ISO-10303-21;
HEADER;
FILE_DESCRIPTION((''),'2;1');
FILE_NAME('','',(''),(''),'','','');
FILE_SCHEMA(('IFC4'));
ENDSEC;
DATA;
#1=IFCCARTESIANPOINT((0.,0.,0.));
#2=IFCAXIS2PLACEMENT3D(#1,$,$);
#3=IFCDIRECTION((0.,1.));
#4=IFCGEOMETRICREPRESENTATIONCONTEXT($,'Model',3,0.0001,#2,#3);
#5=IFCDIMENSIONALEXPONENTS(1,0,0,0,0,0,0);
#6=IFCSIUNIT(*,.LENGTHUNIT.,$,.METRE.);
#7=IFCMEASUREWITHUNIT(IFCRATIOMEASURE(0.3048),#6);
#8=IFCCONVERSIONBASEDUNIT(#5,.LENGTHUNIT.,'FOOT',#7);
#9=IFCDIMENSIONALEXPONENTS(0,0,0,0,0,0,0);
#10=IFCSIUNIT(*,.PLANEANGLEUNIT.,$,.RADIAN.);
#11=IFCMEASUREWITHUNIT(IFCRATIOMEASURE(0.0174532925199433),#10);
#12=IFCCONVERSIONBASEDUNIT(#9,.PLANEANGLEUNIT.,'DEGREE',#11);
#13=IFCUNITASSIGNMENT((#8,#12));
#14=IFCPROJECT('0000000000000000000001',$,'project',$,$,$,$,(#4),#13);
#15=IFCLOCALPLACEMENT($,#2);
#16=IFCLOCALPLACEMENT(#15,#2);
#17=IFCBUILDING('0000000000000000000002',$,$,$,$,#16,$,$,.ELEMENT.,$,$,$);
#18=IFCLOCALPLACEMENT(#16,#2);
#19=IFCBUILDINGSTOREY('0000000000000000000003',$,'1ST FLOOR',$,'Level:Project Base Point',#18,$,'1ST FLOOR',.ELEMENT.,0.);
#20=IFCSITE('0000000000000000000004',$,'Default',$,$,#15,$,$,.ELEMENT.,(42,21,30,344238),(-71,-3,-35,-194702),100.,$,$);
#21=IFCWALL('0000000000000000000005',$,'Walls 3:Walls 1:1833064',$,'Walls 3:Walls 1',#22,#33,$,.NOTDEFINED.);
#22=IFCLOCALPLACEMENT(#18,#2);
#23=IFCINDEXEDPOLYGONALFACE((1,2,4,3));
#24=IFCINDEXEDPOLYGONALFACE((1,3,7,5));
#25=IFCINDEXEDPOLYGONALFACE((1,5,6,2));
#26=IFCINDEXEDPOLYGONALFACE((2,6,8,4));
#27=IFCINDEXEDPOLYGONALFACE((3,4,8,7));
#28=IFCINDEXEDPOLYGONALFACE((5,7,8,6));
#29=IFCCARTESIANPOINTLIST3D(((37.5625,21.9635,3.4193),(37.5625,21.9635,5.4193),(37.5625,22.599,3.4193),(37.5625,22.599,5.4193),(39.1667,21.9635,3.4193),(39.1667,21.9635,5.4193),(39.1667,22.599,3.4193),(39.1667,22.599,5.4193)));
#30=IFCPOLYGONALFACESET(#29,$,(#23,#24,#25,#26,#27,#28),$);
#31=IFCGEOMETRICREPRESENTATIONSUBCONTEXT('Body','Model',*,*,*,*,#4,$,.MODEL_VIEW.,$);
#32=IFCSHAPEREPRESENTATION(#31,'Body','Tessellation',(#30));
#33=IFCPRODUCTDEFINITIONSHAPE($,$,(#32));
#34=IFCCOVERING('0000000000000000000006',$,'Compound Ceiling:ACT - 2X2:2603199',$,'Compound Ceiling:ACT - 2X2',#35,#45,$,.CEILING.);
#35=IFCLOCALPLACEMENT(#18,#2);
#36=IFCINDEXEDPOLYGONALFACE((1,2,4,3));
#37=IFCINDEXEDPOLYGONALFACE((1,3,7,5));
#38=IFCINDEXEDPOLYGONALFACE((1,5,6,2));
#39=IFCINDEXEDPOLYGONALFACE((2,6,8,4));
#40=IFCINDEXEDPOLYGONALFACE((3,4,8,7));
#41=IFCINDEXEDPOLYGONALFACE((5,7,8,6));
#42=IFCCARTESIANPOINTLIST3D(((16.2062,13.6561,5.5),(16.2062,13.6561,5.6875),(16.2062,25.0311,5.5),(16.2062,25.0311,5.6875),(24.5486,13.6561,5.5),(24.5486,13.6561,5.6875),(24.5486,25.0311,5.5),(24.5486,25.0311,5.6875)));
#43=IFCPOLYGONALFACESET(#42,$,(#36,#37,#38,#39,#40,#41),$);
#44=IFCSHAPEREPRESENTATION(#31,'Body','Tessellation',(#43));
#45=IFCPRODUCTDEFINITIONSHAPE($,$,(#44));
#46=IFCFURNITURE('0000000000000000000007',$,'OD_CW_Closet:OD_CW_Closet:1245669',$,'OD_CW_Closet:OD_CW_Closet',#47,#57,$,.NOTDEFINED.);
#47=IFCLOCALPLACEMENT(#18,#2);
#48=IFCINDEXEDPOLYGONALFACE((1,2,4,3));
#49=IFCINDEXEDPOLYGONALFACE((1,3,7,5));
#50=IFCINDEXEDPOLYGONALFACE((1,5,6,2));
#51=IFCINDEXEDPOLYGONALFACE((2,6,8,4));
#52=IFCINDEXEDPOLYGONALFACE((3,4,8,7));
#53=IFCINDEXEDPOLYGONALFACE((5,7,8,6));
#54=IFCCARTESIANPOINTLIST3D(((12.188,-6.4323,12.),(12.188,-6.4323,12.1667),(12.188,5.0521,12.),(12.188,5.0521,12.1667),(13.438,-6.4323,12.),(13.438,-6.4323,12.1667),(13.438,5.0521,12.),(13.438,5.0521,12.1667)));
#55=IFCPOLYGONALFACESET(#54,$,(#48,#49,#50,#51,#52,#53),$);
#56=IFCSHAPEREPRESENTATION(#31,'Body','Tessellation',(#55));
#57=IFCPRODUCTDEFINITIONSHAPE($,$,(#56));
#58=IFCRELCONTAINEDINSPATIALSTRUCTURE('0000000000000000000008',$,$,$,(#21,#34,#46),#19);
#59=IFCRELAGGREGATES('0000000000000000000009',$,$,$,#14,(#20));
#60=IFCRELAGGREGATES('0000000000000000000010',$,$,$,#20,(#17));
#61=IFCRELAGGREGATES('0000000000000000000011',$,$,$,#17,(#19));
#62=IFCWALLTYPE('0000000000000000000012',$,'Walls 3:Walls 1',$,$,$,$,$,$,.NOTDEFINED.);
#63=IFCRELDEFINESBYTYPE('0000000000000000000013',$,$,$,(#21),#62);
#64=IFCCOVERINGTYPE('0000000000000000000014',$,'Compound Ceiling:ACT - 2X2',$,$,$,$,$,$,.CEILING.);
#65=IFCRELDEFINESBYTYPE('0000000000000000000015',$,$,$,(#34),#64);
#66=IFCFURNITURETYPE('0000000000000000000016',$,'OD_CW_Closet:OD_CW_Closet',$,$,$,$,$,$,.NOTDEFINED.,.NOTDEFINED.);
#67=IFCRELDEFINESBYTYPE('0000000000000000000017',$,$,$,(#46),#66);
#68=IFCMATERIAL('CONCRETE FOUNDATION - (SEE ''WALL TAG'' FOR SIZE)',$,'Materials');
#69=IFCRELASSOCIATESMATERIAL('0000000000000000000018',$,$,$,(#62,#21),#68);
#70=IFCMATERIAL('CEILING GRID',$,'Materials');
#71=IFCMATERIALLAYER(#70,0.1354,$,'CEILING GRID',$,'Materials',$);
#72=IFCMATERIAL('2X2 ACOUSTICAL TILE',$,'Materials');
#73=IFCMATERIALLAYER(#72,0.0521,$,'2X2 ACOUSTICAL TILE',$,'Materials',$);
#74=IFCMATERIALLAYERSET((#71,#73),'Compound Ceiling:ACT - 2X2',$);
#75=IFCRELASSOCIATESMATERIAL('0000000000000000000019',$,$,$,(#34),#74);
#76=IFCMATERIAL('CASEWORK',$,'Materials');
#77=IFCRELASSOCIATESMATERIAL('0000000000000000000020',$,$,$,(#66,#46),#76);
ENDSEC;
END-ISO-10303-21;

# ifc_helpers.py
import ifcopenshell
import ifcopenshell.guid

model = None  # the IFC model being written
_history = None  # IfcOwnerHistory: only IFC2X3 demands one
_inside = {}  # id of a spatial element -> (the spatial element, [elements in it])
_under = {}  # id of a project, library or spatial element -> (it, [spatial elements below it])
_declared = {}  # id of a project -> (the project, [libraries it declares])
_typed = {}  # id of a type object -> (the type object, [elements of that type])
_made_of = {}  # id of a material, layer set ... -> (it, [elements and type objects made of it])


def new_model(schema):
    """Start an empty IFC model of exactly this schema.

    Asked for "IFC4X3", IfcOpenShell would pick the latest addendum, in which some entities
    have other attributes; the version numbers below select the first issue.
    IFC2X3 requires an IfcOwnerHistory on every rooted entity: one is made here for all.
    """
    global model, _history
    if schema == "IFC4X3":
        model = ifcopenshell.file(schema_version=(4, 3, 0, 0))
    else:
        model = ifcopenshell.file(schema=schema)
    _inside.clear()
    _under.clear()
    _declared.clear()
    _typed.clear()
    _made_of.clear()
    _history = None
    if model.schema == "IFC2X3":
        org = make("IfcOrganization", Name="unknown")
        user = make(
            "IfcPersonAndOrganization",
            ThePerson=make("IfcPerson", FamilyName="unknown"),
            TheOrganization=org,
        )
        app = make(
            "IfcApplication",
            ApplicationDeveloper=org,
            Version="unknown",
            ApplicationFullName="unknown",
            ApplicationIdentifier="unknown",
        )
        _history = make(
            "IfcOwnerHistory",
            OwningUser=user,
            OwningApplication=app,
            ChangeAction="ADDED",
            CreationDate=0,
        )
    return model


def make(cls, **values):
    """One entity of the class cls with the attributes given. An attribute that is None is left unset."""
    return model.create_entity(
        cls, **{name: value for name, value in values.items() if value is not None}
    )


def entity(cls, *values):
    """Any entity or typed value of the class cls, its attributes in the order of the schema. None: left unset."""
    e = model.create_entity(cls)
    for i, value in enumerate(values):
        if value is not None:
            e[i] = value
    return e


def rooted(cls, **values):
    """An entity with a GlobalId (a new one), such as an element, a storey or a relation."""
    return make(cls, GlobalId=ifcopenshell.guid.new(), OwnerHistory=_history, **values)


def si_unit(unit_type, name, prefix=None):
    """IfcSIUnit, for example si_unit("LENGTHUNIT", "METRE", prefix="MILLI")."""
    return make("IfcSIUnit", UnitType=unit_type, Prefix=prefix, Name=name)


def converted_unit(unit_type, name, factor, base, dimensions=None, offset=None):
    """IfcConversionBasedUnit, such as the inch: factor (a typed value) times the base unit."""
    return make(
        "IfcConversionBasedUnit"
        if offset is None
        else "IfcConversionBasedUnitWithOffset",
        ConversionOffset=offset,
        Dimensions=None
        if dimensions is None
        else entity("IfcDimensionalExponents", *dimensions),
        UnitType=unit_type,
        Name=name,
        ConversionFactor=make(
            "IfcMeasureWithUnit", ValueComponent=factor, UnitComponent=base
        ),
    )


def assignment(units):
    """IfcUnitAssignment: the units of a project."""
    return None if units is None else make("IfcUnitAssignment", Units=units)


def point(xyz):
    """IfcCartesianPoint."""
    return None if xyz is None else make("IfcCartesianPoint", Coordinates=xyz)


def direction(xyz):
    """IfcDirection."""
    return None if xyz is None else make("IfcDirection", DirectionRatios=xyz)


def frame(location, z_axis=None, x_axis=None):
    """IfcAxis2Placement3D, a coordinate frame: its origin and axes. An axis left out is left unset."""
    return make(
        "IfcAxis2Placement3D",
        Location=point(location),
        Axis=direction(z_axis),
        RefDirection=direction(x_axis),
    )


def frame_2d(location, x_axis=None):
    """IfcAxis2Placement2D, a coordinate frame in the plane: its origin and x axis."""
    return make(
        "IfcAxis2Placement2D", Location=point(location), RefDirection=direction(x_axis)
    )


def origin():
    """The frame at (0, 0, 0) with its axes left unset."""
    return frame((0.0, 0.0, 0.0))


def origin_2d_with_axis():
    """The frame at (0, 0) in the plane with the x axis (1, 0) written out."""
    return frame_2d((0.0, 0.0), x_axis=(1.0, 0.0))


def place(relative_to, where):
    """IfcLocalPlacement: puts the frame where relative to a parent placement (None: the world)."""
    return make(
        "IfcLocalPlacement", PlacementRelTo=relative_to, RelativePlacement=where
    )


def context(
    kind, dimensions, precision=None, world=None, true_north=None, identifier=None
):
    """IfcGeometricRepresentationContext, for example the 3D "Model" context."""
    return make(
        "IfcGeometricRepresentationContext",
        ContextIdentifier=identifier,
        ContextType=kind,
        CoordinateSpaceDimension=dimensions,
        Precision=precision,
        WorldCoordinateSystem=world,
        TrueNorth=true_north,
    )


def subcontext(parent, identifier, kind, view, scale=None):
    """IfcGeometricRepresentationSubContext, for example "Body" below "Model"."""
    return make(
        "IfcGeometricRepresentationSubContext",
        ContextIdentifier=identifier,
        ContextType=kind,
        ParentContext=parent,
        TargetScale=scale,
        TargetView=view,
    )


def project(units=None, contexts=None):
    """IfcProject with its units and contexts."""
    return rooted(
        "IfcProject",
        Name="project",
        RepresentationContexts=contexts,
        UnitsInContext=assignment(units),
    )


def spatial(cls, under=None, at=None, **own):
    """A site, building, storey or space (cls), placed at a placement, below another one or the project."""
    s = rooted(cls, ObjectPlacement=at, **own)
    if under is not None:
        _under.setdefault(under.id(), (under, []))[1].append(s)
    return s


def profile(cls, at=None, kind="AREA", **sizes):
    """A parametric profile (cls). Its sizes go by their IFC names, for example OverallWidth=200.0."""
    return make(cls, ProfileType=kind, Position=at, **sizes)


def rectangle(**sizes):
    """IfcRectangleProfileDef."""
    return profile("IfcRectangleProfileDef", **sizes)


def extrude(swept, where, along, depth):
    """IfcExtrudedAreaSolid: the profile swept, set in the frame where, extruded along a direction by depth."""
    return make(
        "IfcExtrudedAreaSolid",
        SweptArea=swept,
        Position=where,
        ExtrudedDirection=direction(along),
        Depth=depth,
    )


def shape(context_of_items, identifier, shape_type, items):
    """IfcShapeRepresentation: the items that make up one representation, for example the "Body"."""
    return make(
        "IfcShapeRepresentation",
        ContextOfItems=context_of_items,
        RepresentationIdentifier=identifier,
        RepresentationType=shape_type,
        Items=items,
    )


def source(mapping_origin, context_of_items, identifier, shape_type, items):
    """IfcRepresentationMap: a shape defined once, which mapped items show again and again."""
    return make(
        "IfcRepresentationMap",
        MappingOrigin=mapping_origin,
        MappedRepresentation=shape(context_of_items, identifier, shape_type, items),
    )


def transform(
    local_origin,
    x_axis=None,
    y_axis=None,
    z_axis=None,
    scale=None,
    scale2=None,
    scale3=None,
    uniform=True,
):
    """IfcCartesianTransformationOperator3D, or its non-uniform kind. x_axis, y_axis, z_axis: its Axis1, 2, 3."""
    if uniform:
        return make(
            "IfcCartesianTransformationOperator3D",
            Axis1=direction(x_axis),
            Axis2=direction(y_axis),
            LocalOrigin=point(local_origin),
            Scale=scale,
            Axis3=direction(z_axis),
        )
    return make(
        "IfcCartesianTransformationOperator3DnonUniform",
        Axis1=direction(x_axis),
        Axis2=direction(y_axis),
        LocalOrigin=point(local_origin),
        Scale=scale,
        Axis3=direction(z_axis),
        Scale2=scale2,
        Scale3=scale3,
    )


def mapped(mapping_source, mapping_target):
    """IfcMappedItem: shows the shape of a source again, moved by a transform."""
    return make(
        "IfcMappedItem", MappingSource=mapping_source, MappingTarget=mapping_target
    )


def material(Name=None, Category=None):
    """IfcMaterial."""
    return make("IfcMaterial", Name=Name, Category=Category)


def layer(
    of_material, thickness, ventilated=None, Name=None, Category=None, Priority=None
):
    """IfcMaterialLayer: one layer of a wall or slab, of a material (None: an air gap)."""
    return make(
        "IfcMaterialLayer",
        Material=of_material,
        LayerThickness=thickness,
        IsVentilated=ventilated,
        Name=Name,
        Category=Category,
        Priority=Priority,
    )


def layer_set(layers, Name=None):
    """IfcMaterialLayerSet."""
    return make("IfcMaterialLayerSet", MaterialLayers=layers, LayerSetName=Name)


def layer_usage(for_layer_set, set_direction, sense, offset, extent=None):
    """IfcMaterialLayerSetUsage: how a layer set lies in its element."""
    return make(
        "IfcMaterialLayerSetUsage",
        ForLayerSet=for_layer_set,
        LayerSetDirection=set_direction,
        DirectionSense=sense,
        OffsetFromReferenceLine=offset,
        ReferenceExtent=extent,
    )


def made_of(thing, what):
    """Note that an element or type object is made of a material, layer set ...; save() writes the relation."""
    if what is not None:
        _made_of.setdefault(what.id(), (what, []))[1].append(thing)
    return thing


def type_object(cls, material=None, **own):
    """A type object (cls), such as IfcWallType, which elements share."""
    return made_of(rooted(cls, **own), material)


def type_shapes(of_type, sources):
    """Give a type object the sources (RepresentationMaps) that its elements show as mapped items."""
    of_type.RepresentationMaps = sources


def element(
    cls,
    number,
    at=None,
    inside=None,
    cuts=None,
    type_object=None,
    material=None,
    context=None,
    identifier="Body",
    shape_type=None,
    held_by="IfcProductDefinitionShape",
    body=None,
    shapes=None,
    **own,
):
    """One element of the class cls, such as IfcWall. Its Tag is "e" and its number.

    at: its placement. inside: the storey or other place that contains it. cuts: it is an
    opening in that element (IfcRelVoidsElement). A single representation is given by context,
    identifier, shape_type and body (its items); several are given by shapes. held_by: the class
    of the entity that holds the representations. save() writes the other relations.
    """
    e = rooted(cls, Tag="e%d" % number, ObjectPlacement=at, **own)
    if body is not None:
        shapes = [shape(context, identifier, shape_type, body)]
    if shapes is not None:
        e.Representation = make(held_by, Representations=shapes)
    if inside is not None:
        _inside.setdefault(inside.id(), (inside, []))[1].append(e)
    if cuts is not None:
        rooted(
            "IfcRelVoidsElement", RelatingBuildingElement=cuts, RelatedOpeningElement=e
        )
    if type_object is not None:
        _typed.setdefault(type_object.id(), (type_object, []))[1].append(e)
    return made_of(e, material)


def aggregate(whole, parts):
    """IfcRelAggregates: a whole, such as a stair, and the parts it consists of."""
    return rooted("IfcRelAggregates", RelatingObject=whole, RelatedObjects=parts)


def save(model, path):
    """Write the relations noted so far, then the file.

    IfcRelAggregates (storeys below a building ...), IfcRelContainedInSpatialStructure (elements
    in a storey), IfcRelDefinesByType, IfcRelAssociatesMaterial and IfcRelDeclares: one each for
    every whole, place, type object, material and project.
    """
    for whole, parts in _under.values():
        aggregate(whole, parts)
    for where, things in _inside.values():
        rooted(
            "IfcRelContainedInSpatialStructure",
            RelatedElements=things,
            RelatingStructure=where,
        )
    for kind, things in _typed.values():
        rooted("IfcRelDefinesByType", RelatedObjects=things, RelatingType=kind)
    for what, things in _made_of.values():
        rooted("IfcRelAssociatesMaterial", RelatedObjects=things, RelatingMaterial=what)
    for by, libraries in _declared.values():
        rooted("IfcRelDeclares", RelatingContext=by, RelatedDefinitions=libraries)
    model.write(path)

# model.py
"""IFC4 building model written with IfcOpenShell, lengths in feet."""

from ifc_helpers import new_model, entity, si_unit, converted_unit, direction, frame, frame_2d, origin, origin_2d_with_axis, place, context, subcontext, project, spatial, rectangle, extrude, source, transform, mapped, material, layer, layer_set, layer_usage, type_object, type_shapes, element, save


model = new_model("IFC4")

# Units and contexts
model_context = context("Model", 3, precision=0.0001, world=origin(), true_north=direction((0.0, 1.0)))
body_context = subcontext(model_context, "Body", "Model", "MODEL_VIEW")
ifc_project = project(units=[converted_unit("LENGTHUNIT", "FOOT", entity("IfcRatioMeasure", 0.3048), si_unit("LENGTHUNIT", "METRE"), dimensions=[1, 0, 0, 0, 0, 0, 0]), converted_unit("PLANEANGLEUNIT", "DEGREE", entity("IfcRatioMeasure", 0.0174532925199433), si_unit("PLANEANGLEUNIT", "RADIAN"), dimensions=[0, 0, 0, 0, 0, 0, 0])], contexts=[model_context])

# Site, building, storey
site_placement = place(None, origin())
site = spatial("IfcSite", under=ifc_project, at=site_placement, Name="Default", CompositionType="ELEMENT", RefLatitude=(42, 21, 30, 344238), RefLongitude=(-71, -3, -35, -194702), RefElevation=100.0)
building_placement = place(site_placement, origin())
building = spatial("IfcBuilding", under=site, at=building_placement, CompositionType="ELEMENT")
storey_placement = place(building_placement, origin())
storey = spatial("IfcBuildingStorey", under=building, at=storey_placement, Name="1ST FLOOR", ObjectType="Level:Project Base Point", LongName="1ST FLOOR", CompositionType="ELEMENT", Elevation=0.0)

# Wall
ifc_material_1 = material(Name="CONCRETE FOUNDATION - (SEE 'WALL TAG' FOR SIZE)", Category="Materials")
wall_type_1 = type_object("IfcWallType", Name="Walls 3:Walls 1", PredefinedType="NOTDEFINED", material=ifc_material_1)
wall_1_placement = place(storey_placement, frame((37.5625, 21.9635, 3.4193)))
element("IfcWall", 1, at=wall_1_placement, inside=storey, type_object=wall_type_1, material=ifc_material_1, Name="Walls 3:Walls 1:1833064", ObjectType="Walls 3:Walls 1", PredefinedType="NOTDEFINED", context=body_context, shape_type="SweptSolid", body=[
    extrude(rectangle(XDim=0.6354, YDim=1.6042, at=origin_2d_with_axis()), frame((0.8021, 0.3177, 0.0), z_axis=(0.0, 0.0, 1.0), x_axis=(0.0, -1.0, 0.0)), (0.0, 0.0, 1.0), 2.0),
])

# Covering
ifc_material_2 = material(Name="CEILING GRID", Category="Materials")
ifc_layer_1 = layer(ifc_material_2, 0.1354, Name="CEILING GRID", Category="Materials")
ifc_material_3 = material(Name="2X2 ACOUSTICAL TILE", Category="Materials")
ifc_layer_2 = layer(ifc_material_3, 0.0521, Name="2X2 ACOUSTICAL TILE", Category="Materials")
ifc_layer_set_1 = layer_set([ifc_layer_1, ifc_layer_2], Name="Compound Ceiling:ACT - 2X2")
ifc_layer_usage_1 = layer_usage(ifc_layer_set_1, "AXIS3", "POSITIVE", 0.0)
covering_type = type_object("IfcCoveringType", Name="Compound Ceiling:ACT - 2X2", PredefinedType="CEILING")
covering_placement = place(storey_placement, frame((16.2062, 13.6561, 5.5)))
element("IfcCovering", 2, at=covering_placement, inside=storey, type_object=covering_type, material=ifc_layer_usage_1, Name="Compound Ceiling:ACT - 2X2:2603199", ObjectType="Compound Ceiling:ACT - 2X2", PredefinedType="CEILING", context=body_context, shape_type="SweptSolid", body=[
    extrude(rectangle(XDim=8.3424, YDim=11.375, at=frame_2d((0.0, 0.0), x_axis=(1.0, 0.0))), frame((4.1712, 5.6875, 0.0), z_axis=(0.0, 0.0, 1.0), x_axis=(-1.0, 0.0, 0.0)), (0.0, 0.0, 1.0), 0.1875),
])

# Furniture
ifc_material_4 = material(Name="CASEWORK", Category="Materials")
furniture_type = type_object("IfcFurnitureType", Name="OD_CW_Closet:OD_CW_Closet", AssemblyPlace="NOTDEFINED", PredefinedType="NOTDEFINED", material=ifc_material_4)
shared_shape_1 = source(origin(), body_context, "Body", "SweptSolid", [
    extrude(rectangle(XDim=11.4844, YDim=1.25, at=frame_2d((0.0, 0.0), x_axis=(1.0, 0.0))), frame((5.7422, 0.625, 0.0)), (0.0, 0.0, 1.0), 0.1667),
])
type_shapes(furniture_type, [shared_shape_1])
furniture_placement = place(storey_placement, frame((13.438, -6.4323, 12.0), z_axis=(0.0, 0.0, 1.0), x_axis=(0.0, 1.0, 0.0)))
element("IfcFurniture", 3, at=furniture_placement, inside=storey, type_object=furniture_type, material=ifc_material_4, Name="OD_CW_Closet:OD_CW_Closet:1245669", ObjectType="OD_CW_Closet:OD_CW_Closet", PredefinedType="NOTDEFINED", context=body_context, shape_type="MappedRepresentation", body=[
    mapped(shared_shape_1, transform((0.0, 0.0, 0.0), scale=1.0)),
])

save(model, "model.ifc")
